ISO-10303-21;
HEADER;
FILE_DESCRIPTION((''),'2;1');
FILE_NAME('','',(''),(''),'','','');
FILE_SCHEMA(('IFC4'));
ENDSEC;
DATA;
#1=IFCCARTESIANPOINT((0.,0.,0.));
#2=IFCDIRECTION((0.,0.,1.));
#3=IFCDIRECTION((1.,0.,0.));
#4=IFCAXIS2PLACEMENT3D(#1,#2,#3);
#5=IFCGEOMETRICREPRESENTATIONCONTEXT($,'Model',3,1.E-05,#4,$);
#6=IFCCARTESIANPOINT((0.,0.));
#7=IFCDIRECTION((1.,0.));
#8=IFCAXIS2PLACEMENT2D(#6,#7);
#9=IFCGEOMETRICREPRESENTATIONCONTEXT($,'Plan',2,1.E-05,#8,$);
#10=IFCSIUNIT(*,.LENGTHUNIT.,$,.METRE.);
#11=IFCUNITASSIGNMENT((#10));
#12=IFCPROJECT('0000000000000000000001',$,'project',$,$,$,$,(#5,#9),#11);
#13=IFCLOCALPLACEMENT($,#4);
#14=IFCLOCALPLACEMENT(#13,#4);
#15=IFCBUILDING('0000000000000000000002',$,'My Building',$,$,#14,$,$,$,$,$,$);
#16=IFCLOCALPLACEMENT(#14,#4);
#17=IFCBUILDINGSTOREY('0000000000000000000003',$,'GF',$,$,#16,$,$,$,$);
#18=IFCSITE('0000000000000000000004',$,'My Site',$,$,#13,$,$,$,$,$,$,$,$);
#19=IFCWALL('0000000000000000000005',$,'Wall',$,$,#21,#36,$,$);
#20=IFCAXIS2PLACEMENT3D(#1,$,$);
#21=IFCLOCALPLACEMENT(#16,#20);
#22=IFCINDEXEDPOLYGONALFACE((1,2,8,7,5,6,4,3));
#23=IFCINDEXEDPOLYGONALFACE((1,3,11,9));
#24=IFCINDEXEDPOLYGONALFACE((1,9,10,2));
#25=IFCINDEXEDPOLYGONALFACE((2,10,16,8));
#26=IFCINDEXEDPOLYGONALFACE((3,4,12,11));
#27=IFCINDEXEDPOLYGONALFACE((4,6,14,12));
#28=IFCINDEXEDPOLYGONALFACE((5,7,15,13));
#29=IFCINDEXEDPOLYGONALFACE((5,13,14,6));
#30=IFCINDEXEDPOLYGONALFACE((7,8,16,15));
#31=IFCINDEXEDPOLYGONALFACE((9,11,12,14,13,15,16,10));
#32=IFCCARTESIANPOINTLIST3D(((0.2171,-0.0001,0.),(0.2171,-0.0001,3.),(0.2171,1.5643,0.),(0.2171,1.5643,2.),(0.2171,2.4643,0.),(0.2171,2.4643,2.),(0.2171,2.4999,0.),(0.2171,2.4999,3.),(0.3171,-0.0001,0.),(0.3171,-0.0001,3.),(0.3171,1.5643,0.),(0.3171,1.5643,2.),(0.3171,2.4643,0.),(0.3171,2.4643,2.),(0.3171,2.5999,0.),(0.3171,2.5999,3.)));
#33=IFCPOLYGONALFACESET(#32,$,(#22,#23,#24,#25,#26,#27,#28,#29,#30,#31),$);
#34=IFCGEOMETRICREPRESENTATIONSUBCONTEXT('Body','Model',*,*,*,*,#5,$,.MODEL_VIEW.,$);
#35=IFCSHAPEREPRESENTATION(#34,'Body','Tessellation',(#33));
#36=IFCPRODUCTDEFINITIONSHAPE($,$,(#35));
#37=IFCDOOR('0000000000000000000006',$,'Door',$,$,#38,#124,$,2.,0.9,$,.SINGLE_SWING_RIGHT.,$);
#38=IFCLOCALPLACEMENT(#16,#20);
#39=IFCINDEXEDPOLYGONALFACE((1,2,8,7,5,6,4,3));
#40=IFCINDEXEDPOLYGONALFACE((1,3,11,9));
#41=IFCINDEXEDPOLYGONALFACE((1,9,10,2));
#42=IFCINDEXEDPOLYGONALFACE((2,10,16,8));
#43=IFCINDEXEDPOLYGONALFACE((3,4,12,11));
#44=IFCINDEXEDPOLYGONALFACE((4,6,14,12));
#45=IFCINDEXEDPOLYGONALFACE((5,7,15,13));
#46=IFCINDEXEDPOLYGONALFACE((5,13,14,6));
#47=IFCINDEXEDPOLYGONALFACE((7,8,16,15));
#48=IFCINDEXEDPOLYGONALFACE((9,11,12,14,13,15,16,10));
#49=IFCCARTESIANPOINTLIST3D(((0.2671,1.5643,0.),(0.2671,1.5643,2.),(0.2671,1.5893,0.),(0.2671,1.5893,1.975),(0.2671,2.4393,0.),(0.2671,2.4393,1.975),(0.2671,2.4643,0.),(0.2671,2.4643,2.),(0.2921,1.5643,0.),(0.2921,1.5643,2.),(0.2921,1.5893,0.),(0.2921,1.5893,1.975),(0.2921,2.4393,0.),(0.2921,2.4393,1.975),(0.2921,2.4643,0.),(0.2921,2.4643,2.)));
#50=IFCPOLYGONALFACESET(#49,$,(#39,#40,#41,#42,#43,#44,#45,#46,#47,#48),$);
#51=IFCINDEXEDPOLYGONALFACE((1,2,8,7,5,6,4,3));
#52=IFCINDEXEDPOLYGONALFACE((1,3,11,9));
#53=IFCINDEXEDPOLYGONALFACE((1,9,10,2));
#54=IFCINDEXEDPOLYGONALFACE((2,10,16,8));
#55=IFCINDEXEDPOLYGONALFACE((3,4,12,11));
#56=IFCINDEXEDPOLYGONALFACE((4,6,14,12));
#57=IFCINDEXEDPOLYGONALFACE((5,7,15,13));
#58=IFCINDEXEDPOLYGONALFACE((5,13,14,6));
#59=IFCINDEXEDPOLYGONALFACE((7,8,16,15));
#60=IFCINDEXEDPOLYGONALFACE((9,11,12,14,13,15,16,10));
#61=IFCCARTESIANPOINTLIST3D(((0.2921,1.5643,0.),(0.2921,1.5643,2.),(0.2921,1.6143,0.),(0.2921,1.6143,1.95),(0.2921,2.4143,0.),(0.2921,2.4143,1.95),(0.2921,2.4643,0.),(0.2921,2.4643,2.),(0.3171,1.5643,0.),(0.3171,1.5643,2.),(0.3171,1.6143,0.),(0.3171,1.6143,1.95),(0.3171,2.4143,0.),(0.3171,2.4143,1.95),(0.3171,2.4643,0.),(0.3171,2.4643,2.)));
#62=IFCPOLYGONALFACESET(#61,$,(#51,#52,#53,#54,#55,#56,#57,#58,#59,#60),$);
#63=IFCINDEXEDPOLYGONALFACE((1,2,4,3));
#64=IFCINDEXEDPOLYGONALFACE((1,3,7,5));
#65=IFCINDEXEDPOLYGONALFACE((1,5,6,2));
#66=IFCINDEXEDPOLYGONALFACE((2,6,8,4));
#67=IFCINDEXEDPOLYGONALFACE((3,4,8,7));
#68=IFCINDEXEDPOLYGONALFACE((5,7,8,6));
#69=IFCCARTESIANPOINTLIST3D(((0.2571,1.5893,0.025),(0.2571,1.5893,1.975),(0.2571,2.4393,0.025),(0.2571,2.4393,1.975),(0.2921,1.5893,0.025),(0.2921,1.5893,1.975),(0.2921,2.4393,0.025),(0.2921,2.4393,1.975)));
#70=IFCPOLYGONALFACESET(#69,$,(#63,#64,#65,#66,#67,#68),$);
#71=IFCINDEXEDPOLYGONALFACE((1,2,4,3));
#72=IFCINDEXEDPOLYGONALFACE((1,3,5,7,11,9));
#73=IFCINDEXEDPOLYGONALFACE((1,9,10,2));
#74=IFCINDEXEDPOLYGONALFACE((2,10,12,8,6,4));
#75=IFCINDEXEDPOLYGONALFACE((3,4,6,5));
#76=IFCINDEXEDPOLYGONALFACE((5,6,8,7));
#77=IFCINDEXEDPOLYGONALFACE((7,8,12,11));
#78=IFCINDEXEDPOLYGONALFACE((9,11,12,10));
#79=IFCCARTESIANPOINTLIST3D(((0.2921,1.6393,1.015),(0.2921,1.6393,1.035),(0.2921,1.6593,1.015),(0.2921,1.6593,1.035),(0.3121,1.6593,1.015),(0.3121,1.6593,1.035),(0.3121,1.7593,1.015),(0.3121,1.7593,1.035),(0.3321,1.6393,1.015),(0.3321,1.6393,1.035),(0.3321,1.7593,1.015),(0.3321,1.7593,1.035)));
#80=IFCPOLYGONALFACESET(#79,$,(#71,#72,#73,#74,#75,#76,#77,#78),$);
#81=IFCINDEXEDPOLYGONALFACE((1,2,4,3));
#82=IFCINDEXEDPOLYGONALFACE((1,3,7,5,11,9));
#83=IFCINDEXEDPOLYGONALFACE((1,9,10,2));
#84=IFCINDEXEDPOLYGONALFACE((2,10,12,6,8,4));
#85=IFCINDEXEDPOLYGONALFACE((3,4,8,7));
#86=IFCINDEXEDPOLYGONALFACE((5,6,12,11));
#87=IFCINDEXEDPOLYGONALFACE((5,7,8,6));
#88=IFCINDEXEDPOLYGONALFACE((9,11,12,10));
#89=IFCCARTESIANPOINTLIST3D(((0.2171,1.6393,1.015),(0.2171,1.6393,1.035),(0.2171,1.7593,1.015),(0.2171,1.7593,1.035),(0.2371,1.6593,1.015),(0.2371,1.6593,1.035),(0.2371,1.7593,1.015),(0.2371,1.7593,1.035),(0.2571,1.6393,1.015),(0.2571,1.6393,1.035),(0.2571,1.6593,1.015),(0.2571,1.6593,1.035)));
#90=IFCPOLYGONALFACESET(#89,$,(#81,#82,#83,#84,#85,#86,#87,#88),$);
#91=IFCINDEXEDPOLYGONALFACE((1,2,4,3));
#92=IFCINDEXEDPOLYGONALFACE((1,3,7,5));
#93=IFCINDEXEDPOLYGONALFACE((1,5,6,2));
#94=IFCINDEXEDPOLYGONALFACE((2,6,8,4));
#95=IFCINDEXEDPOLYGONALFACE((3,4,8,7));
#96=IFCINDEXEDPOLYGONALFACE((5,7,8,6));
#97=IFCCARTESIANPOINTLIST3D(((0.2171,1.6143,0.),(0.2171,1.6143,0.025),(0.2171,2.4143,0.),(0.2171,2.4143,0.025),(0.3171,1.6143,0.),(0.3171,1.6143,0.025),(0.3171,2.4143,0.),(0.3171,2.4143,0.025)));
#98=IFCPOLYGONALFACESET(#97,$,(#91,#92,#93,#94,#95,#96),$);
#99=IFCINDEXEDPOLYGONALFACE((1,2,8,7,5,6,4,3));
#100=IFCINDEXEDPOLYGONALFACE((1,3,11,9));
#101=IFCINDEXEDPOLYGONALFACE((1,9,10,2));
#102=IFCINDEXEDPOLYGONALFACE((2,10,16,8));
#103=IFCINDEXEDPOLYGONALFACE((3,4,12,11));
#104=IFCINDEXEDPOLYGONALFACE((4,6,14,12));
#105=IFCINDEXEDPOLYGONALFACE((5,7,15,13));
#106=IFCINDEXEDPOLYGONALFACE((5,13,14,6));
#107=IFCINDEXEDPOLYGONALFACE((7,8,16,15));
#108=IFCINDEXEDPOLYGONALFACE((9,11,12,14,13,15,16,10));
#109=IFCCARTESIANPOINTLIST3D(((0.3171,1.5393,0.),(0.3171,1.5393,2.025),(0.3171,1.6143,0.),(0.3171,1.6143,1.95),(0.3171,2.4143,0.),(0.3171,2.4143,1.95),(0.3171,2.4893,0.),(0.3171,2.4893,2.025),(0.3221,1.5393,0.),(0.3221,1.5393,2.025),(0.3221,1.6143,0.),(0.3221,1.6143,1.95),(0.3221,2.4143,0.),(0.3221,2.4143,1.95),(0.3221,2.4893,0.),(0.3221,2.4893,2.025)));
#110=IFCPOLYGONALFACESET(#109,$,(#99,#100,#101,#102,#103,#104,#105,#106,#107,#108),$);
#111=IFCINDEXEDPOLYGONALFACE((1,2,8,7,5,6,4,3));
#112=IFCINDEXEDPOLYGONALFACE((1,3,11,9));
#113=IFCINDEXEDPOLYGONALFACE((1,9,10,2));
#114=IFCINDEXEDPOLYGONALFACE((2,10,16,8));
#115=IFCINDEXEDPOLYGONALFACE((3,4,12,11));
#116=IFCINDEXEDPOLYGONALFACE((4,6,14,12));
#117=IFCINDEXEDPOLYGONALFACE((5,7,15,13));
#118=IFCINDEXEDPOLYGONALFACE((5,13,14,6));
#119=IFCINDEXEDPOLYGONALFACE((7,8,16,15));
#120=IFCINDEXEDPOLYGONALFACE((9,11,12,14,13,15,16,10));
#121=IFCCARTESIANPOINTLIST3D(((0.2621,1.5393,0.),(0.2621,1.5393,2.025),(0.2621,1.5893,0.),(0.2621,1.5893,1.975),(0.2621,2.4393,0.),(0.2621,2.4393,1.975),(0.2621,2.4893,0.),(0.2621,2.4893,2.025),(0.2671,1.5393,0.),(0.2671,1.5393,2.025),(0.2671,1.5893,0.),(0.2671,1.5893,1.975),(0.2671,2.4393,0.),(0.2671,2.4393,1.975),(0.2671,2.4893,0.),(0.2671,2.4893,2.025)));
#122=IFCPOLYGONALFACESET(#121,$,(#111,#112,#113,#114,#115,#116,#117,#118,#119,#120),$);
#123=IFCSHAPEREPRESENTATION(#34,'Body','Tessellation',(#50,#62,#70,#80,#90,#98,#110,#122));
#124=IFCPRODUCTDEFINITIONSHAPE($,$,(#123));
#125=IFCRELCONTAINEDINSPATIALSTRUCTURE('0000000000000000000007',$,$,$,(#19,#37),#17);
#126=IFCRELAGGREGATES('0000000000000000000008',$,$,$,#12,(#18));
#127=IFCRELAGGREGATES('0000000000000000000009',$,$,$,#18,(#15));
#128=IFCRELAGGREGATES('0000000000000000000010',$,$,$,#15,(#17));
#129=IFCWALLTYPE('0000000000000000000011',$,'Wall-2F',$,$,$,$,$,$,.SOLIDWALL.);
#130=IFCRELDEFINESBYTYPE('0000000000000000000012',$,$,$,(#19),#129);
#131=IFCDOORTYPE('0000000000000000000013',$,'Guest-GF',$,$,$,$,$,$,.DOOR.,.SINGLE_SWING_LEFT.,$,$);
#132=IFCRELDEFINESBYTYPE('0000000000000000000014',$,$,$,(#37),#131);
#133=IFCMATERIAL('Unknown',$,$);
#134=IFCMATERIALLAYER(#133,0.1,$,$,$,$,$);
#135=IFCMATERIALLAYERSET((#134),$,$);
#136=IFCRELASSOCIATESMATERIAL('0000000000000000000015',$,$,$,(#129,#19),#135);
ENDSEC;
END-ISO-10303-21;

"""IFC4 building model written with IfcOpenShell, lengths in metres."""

from ifc_helpers import new_model, entity, si_unit, frame, origin_with_axes, origin_2d_with_axis, place, context, subcontext, project, spatial, line, indexed_curve, outline, extrude, shape, source, transform, mapped, material, layer, layer_set, layer_usage, type_object, type_shapes, element, fill, save


model = new_model("IFC4")

# Units and contexts
model_context = context("Model", 3, precision=1e-05, world=origin_with_axes())
plan_context = context("Plan", 2, precision=1e-05, world=origin_2d_with_axis())
body_context_1 = subcontext(model_context, "Body", "Model", "MODEL_VIEW")
body_context_2 = subcontext(plan_context, "Body", "Plan", "PLAN_VIEW")
ifc_project = project(units=[si_unit("LENGTHUNIT", "METRE")], contexts=[model_context, plan_context])

# Site, building, storey
site_placement = place(None, origin_with_axes())
site = spatial("IfcSite", under=ifc_project, at=site_placement, Name="My Site")
building_placement = place(site_placement, origin_with_axes())
building = spatial("IfcBuilding", under=site, at=building_placement, Name="My Building")
storey_placement = place(building_placement, origin_with_axes())
storey = spatial("IfcBuildingStorey", under=building, at=storey_placement, Name="GF")

# Shared definitions
ifc_material = material(Name="Unknown")

# Shared definitions
ifc_layer_1 = layer(ifc_material, 0.1)
ifc_layer_set_1 = layer_set([ifc_layer_1])
wall_type = type_object("IfcWallType", Name="Wall-2F", PredefinedType="SOLIDWALL", material=ifc_layer_set_1)

# Wall, opening, door
ifc_layer_usage_1 = layer_usage(ifc_layer_set_1, "AXIS2", "POSITIVE", 0.0)
wall_1_placement = place(storey_placement, frame((0.3171, -0.0001, 0.0), z_axis=(0.0, 0.0, 1.0), x_axis=(0.0, 1.0, 0.0)))
wall_1 = element("IfcWall", 1, at=wall_1_placement, inside=storey, type_object=wall_type, material=ifc_layer_usage_1, Name="Wall", context=body_context_1, shape_type="SweptSolid", body=[
    extrude(outline(indexed_curve([(0.0, 0.0), (0.0, 0.1), (2.5, 0.1), (2.6, 0.0)], segments=[line(1, 2, 3, 4, 1)])), origin_with_axes(), (0.0, 0.0, 1.0), 3.0),
])
shared_shape_1 = source(origin_with_axes(), body_context_1, "Body", "SweptSolid", [
    extrude(outline(indexed_curve([(0.0, 0.0), (0.9, 0.0), (0.9, 2.0), (0.0, 2.0)], segments=[line(1, 2, 3, 4, 1)])), frame((0.0, -0.6, 0.0), z_axis=(0.0, -1.0, 0.0), x_axis=(1.0, 0.0, 0.0)), (0.0, 0.0, -1.0), 1.2),
])
opening_1_placement = place(wall_1_placement, frame((1.5644, 0.0, 0.0), z_axis=(0.0, 0.0, 1.0), x_axis=(1.0, 0.0, 0.0)))
opening_1 = element("IfcOpeningElement", 2, at=opening_1_placement, cuts=wall_1, PredefinedType="OPENING", context=body_context_1, shape_type="MappedRepresentation", body=[
    mapped(shared_shape_1, transform((0.0, 0.0, 0.0), x_axis=(1.0, 0.0, 0.0), y_axis=(0.0, 1.0, 0.0), z_axis=(0.0, 0.0, 1.0), scale=1.0)),
])
door_type_1 = type_object("IfcDoorType", Name="Guest-GF", OperationType="SINGLE_SWING_LEFT", PredefinedType="DOOR")
shared_shape_2 = source(origin_with_axes(), body_context_1, "Body", "SweptSolid", [
    extrude(outline(indexed_curve([(0.0, 0.0), (0.0, 2.0), (0.9, 2.0), (0.9, 0.0), (0.875, 0.0), (0.875, 1.975), (0.025, 1.975), (0.025, 0.0)], segments=[line(1, 2, 3, 4, 5, 6, 7, 8, 1)])), frame((0.0, 0.025, 0.0), z_axis=(0.0, -1.0, 0.0), x_axis=(1.0, 0.0, 0.0)), (0.0, 0.0, -1.0), 0.025),
    extrude(outline(indexed_curve([(0.0, 0.0), (0.0, 2.0), (0.9, 2.0), (0.9, 0.0), (0.85, 0.0), (0.85, 1.95), (0.05, 1.95), (0.05, 0.0)], segments=[line(1, 2, 3, 4, 5, 6, 7, 8, 1)])), frame((0.0, 0.0, 0.0), z_axis=(0.0, -1.0, 0.0), x_axis=(1.0, 0.0, 0.0)), (0.0, 0.0, -1.0), 0.025),
    extrude(outline(indexed_curve([(0.0, 0.0), (0.85, 0.0), (0.85, 0.035), (0.0, 0.035)], segments=[line(1, 2, 3, 4, 1)])), frame((0.025, 0.025, 0.025), z_axis=(0.0, 0.0, 1.0), x_axis=(1.0, 0.0, 0.0)), (0.0, 0.0, 1.0), 1.95),
    extrude(outline(indexed_curve([(0.0, 0.0), (0.0, -0.04), (0.12, -0.04), (0.12, -0.02), (0.02, -0.02), (0.02, 0.0)], segments=[line(1, 2, 3, 4, 5, 6, 1)])), frame((0.075, 0.025, 1.015), z_axis=(0.0, 0.0, 1.0), x_axis=(1.0, 0.0, 0.0)), (0.0, 0.0, 1.0), 0.02),
    extrude(outline(indexed_curve([(0.0, 0.0), (0.0, 0.04), (0.12, 0.04), (0.12, 0.02), (0.02, 0.02), (0.02, 0.0)], segments=[line(1, 2, 3, 4, 5, 6, 1)])), frame((0.075, 0.06, 1.015), z_axis=(0.0, 0.0, 1.0), x_axis=(1.0, 0.0, 0.0)), (0.0, 0.0, 1.0), 0.02),
    extrude(outline(indexed_curve([(0.0, 0.0), (0.8, 0.0), (0.8, 0.1), (0.0, 0.1)], segments=[line(1, 2, 3, 4, 1)])), frame((0.05, 0.0, 0.0), z_axis=(0.0, 0.0, 1.0), x_axis=(1.0, 0.0, 0.0)), (0.0, 0.0, 1.0), 0.025),
    extrude(outline(indexed_curve([(0.0, 0.0), (0.0, 2.025), (0.95, 2.025), (0.95, 0.0), (0.875, 0.0), (0.875, 1.95), (0.075, 1.95), (0.075, 0.0)], segments=[line(1, 2, 3, 4, 5, 6, 7, 8, 1)])), frame((-0.025, -0.005, 0.0), z_axis=(0.0, -1.0, 0.0), x_axis=(1.0, 0.0, 0.0)), (0.0, 0.0, -1.0), 0.005),
    extrude(outline(indexed_curve([(0.0, 0.0), (0.0, 2.025), (0.95, 2.025), (0.95, 0.0), (0.9, 0.0), (0.9, 1.975), (0.05, 1.975), (0.05, 0.0)], segments=[line(1, 2, 3, 4, 5, 6, 7, 8, 1)])), frame((-0.025, 0.05, 0.0), z_axis=(0.0, -1.0, 0.0), x_axis=(1.0, 0.0, 0.0)), (0.0, 0.0, -1.0), 0.005),
])
shared_shape_3 = source(origin_with_axes(), body_context_2, "Body", "Curve2D", [
    entity("IfcIndexedPolyCurve", entity("IfcCartesianPointList2D", [[0.0, 0.0], [0.0, 0.05], [0.025, 0.05], [0.025, 0.025], [0.05, 0.025], [0.05, 0.0]]), [entity("IfcLineIndex", [1, 2, 3, 4, 5, 6, 1])]),
    entity("IfcIndexedPolyCurve", entity("IfcCartesianPointList2D", [[0.9, 0.0], [0.9, 0.05], [0.875, 0.05], [0.875, 0.025], [0.85, 0.025], [0.85, 0.0]]), [entity("IfcLineIndex", [1, 2, 3, 4, 5, 6, 1])]),
    entity("IfcTrimmedCurve", entity("IfcEllipse", entity("IfcAxis2Placement2D", entity("IfcCartesianPoint", [0.84, 0.05]), entity("IfcDirection", [1.0, 0.0])), 0.815, 0.85), [entity("IfcCartesianPoint", [0.84, 0.9])], [entity("IfcCartesianPoint", [0.025, 0.05])], True, "CARTESIAN"),
    entity("IfcIndexedPolyCurve", entity("IfcCartesianPointList2D", [[0.875, 0.05], [0.84, 0.05], [0.84, 0.9], [0.875, 0.9]]), [entity("IfcLineIndex", [1, 2, 3, 4, 1])]),
])
type_shapes(door_type_1, [shared_shape_2, shared_shape_3])
door_1_placement = place(opening_1_placement, frame((0.0, 0.0, 0.0), z_axis=(0.0, 0.0, 1.0), x_axis=(1.0, 0.0, 0.0)))
door_1 = element("IfcDoor", 3, at=door_1_placement, inside=storey, type_object=door_type_1, Name="Door", OperationType="SINGLE_SWING_RIGHT", OverallHeight=2.0, OverallWidth=0.9, shapes=[
    shape(body_context_1, "Body", "MappedRepresentation", [mapped(shared_shape_2, transform((0.0, 0.0, 0.0), x_axis=(1.0, 0.0, 0.0), y_axis=(0.0, 1.0, 0.0), z_axis=(0.0, 0.0, 1.0), scale=1.0))]),
    shape(body_context_2, "Body", "MappedRepresentation", [mapped(shared_shape_3, transform((0.0, 0.0, 0.0), x_axis=(1.0, 0.0, 0.0), y_axis=(0.0, 1.0, 0.0), z_axis=(0.0, 0.0, 1.0), scale=1.0))]),
])
fill(opening_1, door_1)

save(model, "model.ifc")
